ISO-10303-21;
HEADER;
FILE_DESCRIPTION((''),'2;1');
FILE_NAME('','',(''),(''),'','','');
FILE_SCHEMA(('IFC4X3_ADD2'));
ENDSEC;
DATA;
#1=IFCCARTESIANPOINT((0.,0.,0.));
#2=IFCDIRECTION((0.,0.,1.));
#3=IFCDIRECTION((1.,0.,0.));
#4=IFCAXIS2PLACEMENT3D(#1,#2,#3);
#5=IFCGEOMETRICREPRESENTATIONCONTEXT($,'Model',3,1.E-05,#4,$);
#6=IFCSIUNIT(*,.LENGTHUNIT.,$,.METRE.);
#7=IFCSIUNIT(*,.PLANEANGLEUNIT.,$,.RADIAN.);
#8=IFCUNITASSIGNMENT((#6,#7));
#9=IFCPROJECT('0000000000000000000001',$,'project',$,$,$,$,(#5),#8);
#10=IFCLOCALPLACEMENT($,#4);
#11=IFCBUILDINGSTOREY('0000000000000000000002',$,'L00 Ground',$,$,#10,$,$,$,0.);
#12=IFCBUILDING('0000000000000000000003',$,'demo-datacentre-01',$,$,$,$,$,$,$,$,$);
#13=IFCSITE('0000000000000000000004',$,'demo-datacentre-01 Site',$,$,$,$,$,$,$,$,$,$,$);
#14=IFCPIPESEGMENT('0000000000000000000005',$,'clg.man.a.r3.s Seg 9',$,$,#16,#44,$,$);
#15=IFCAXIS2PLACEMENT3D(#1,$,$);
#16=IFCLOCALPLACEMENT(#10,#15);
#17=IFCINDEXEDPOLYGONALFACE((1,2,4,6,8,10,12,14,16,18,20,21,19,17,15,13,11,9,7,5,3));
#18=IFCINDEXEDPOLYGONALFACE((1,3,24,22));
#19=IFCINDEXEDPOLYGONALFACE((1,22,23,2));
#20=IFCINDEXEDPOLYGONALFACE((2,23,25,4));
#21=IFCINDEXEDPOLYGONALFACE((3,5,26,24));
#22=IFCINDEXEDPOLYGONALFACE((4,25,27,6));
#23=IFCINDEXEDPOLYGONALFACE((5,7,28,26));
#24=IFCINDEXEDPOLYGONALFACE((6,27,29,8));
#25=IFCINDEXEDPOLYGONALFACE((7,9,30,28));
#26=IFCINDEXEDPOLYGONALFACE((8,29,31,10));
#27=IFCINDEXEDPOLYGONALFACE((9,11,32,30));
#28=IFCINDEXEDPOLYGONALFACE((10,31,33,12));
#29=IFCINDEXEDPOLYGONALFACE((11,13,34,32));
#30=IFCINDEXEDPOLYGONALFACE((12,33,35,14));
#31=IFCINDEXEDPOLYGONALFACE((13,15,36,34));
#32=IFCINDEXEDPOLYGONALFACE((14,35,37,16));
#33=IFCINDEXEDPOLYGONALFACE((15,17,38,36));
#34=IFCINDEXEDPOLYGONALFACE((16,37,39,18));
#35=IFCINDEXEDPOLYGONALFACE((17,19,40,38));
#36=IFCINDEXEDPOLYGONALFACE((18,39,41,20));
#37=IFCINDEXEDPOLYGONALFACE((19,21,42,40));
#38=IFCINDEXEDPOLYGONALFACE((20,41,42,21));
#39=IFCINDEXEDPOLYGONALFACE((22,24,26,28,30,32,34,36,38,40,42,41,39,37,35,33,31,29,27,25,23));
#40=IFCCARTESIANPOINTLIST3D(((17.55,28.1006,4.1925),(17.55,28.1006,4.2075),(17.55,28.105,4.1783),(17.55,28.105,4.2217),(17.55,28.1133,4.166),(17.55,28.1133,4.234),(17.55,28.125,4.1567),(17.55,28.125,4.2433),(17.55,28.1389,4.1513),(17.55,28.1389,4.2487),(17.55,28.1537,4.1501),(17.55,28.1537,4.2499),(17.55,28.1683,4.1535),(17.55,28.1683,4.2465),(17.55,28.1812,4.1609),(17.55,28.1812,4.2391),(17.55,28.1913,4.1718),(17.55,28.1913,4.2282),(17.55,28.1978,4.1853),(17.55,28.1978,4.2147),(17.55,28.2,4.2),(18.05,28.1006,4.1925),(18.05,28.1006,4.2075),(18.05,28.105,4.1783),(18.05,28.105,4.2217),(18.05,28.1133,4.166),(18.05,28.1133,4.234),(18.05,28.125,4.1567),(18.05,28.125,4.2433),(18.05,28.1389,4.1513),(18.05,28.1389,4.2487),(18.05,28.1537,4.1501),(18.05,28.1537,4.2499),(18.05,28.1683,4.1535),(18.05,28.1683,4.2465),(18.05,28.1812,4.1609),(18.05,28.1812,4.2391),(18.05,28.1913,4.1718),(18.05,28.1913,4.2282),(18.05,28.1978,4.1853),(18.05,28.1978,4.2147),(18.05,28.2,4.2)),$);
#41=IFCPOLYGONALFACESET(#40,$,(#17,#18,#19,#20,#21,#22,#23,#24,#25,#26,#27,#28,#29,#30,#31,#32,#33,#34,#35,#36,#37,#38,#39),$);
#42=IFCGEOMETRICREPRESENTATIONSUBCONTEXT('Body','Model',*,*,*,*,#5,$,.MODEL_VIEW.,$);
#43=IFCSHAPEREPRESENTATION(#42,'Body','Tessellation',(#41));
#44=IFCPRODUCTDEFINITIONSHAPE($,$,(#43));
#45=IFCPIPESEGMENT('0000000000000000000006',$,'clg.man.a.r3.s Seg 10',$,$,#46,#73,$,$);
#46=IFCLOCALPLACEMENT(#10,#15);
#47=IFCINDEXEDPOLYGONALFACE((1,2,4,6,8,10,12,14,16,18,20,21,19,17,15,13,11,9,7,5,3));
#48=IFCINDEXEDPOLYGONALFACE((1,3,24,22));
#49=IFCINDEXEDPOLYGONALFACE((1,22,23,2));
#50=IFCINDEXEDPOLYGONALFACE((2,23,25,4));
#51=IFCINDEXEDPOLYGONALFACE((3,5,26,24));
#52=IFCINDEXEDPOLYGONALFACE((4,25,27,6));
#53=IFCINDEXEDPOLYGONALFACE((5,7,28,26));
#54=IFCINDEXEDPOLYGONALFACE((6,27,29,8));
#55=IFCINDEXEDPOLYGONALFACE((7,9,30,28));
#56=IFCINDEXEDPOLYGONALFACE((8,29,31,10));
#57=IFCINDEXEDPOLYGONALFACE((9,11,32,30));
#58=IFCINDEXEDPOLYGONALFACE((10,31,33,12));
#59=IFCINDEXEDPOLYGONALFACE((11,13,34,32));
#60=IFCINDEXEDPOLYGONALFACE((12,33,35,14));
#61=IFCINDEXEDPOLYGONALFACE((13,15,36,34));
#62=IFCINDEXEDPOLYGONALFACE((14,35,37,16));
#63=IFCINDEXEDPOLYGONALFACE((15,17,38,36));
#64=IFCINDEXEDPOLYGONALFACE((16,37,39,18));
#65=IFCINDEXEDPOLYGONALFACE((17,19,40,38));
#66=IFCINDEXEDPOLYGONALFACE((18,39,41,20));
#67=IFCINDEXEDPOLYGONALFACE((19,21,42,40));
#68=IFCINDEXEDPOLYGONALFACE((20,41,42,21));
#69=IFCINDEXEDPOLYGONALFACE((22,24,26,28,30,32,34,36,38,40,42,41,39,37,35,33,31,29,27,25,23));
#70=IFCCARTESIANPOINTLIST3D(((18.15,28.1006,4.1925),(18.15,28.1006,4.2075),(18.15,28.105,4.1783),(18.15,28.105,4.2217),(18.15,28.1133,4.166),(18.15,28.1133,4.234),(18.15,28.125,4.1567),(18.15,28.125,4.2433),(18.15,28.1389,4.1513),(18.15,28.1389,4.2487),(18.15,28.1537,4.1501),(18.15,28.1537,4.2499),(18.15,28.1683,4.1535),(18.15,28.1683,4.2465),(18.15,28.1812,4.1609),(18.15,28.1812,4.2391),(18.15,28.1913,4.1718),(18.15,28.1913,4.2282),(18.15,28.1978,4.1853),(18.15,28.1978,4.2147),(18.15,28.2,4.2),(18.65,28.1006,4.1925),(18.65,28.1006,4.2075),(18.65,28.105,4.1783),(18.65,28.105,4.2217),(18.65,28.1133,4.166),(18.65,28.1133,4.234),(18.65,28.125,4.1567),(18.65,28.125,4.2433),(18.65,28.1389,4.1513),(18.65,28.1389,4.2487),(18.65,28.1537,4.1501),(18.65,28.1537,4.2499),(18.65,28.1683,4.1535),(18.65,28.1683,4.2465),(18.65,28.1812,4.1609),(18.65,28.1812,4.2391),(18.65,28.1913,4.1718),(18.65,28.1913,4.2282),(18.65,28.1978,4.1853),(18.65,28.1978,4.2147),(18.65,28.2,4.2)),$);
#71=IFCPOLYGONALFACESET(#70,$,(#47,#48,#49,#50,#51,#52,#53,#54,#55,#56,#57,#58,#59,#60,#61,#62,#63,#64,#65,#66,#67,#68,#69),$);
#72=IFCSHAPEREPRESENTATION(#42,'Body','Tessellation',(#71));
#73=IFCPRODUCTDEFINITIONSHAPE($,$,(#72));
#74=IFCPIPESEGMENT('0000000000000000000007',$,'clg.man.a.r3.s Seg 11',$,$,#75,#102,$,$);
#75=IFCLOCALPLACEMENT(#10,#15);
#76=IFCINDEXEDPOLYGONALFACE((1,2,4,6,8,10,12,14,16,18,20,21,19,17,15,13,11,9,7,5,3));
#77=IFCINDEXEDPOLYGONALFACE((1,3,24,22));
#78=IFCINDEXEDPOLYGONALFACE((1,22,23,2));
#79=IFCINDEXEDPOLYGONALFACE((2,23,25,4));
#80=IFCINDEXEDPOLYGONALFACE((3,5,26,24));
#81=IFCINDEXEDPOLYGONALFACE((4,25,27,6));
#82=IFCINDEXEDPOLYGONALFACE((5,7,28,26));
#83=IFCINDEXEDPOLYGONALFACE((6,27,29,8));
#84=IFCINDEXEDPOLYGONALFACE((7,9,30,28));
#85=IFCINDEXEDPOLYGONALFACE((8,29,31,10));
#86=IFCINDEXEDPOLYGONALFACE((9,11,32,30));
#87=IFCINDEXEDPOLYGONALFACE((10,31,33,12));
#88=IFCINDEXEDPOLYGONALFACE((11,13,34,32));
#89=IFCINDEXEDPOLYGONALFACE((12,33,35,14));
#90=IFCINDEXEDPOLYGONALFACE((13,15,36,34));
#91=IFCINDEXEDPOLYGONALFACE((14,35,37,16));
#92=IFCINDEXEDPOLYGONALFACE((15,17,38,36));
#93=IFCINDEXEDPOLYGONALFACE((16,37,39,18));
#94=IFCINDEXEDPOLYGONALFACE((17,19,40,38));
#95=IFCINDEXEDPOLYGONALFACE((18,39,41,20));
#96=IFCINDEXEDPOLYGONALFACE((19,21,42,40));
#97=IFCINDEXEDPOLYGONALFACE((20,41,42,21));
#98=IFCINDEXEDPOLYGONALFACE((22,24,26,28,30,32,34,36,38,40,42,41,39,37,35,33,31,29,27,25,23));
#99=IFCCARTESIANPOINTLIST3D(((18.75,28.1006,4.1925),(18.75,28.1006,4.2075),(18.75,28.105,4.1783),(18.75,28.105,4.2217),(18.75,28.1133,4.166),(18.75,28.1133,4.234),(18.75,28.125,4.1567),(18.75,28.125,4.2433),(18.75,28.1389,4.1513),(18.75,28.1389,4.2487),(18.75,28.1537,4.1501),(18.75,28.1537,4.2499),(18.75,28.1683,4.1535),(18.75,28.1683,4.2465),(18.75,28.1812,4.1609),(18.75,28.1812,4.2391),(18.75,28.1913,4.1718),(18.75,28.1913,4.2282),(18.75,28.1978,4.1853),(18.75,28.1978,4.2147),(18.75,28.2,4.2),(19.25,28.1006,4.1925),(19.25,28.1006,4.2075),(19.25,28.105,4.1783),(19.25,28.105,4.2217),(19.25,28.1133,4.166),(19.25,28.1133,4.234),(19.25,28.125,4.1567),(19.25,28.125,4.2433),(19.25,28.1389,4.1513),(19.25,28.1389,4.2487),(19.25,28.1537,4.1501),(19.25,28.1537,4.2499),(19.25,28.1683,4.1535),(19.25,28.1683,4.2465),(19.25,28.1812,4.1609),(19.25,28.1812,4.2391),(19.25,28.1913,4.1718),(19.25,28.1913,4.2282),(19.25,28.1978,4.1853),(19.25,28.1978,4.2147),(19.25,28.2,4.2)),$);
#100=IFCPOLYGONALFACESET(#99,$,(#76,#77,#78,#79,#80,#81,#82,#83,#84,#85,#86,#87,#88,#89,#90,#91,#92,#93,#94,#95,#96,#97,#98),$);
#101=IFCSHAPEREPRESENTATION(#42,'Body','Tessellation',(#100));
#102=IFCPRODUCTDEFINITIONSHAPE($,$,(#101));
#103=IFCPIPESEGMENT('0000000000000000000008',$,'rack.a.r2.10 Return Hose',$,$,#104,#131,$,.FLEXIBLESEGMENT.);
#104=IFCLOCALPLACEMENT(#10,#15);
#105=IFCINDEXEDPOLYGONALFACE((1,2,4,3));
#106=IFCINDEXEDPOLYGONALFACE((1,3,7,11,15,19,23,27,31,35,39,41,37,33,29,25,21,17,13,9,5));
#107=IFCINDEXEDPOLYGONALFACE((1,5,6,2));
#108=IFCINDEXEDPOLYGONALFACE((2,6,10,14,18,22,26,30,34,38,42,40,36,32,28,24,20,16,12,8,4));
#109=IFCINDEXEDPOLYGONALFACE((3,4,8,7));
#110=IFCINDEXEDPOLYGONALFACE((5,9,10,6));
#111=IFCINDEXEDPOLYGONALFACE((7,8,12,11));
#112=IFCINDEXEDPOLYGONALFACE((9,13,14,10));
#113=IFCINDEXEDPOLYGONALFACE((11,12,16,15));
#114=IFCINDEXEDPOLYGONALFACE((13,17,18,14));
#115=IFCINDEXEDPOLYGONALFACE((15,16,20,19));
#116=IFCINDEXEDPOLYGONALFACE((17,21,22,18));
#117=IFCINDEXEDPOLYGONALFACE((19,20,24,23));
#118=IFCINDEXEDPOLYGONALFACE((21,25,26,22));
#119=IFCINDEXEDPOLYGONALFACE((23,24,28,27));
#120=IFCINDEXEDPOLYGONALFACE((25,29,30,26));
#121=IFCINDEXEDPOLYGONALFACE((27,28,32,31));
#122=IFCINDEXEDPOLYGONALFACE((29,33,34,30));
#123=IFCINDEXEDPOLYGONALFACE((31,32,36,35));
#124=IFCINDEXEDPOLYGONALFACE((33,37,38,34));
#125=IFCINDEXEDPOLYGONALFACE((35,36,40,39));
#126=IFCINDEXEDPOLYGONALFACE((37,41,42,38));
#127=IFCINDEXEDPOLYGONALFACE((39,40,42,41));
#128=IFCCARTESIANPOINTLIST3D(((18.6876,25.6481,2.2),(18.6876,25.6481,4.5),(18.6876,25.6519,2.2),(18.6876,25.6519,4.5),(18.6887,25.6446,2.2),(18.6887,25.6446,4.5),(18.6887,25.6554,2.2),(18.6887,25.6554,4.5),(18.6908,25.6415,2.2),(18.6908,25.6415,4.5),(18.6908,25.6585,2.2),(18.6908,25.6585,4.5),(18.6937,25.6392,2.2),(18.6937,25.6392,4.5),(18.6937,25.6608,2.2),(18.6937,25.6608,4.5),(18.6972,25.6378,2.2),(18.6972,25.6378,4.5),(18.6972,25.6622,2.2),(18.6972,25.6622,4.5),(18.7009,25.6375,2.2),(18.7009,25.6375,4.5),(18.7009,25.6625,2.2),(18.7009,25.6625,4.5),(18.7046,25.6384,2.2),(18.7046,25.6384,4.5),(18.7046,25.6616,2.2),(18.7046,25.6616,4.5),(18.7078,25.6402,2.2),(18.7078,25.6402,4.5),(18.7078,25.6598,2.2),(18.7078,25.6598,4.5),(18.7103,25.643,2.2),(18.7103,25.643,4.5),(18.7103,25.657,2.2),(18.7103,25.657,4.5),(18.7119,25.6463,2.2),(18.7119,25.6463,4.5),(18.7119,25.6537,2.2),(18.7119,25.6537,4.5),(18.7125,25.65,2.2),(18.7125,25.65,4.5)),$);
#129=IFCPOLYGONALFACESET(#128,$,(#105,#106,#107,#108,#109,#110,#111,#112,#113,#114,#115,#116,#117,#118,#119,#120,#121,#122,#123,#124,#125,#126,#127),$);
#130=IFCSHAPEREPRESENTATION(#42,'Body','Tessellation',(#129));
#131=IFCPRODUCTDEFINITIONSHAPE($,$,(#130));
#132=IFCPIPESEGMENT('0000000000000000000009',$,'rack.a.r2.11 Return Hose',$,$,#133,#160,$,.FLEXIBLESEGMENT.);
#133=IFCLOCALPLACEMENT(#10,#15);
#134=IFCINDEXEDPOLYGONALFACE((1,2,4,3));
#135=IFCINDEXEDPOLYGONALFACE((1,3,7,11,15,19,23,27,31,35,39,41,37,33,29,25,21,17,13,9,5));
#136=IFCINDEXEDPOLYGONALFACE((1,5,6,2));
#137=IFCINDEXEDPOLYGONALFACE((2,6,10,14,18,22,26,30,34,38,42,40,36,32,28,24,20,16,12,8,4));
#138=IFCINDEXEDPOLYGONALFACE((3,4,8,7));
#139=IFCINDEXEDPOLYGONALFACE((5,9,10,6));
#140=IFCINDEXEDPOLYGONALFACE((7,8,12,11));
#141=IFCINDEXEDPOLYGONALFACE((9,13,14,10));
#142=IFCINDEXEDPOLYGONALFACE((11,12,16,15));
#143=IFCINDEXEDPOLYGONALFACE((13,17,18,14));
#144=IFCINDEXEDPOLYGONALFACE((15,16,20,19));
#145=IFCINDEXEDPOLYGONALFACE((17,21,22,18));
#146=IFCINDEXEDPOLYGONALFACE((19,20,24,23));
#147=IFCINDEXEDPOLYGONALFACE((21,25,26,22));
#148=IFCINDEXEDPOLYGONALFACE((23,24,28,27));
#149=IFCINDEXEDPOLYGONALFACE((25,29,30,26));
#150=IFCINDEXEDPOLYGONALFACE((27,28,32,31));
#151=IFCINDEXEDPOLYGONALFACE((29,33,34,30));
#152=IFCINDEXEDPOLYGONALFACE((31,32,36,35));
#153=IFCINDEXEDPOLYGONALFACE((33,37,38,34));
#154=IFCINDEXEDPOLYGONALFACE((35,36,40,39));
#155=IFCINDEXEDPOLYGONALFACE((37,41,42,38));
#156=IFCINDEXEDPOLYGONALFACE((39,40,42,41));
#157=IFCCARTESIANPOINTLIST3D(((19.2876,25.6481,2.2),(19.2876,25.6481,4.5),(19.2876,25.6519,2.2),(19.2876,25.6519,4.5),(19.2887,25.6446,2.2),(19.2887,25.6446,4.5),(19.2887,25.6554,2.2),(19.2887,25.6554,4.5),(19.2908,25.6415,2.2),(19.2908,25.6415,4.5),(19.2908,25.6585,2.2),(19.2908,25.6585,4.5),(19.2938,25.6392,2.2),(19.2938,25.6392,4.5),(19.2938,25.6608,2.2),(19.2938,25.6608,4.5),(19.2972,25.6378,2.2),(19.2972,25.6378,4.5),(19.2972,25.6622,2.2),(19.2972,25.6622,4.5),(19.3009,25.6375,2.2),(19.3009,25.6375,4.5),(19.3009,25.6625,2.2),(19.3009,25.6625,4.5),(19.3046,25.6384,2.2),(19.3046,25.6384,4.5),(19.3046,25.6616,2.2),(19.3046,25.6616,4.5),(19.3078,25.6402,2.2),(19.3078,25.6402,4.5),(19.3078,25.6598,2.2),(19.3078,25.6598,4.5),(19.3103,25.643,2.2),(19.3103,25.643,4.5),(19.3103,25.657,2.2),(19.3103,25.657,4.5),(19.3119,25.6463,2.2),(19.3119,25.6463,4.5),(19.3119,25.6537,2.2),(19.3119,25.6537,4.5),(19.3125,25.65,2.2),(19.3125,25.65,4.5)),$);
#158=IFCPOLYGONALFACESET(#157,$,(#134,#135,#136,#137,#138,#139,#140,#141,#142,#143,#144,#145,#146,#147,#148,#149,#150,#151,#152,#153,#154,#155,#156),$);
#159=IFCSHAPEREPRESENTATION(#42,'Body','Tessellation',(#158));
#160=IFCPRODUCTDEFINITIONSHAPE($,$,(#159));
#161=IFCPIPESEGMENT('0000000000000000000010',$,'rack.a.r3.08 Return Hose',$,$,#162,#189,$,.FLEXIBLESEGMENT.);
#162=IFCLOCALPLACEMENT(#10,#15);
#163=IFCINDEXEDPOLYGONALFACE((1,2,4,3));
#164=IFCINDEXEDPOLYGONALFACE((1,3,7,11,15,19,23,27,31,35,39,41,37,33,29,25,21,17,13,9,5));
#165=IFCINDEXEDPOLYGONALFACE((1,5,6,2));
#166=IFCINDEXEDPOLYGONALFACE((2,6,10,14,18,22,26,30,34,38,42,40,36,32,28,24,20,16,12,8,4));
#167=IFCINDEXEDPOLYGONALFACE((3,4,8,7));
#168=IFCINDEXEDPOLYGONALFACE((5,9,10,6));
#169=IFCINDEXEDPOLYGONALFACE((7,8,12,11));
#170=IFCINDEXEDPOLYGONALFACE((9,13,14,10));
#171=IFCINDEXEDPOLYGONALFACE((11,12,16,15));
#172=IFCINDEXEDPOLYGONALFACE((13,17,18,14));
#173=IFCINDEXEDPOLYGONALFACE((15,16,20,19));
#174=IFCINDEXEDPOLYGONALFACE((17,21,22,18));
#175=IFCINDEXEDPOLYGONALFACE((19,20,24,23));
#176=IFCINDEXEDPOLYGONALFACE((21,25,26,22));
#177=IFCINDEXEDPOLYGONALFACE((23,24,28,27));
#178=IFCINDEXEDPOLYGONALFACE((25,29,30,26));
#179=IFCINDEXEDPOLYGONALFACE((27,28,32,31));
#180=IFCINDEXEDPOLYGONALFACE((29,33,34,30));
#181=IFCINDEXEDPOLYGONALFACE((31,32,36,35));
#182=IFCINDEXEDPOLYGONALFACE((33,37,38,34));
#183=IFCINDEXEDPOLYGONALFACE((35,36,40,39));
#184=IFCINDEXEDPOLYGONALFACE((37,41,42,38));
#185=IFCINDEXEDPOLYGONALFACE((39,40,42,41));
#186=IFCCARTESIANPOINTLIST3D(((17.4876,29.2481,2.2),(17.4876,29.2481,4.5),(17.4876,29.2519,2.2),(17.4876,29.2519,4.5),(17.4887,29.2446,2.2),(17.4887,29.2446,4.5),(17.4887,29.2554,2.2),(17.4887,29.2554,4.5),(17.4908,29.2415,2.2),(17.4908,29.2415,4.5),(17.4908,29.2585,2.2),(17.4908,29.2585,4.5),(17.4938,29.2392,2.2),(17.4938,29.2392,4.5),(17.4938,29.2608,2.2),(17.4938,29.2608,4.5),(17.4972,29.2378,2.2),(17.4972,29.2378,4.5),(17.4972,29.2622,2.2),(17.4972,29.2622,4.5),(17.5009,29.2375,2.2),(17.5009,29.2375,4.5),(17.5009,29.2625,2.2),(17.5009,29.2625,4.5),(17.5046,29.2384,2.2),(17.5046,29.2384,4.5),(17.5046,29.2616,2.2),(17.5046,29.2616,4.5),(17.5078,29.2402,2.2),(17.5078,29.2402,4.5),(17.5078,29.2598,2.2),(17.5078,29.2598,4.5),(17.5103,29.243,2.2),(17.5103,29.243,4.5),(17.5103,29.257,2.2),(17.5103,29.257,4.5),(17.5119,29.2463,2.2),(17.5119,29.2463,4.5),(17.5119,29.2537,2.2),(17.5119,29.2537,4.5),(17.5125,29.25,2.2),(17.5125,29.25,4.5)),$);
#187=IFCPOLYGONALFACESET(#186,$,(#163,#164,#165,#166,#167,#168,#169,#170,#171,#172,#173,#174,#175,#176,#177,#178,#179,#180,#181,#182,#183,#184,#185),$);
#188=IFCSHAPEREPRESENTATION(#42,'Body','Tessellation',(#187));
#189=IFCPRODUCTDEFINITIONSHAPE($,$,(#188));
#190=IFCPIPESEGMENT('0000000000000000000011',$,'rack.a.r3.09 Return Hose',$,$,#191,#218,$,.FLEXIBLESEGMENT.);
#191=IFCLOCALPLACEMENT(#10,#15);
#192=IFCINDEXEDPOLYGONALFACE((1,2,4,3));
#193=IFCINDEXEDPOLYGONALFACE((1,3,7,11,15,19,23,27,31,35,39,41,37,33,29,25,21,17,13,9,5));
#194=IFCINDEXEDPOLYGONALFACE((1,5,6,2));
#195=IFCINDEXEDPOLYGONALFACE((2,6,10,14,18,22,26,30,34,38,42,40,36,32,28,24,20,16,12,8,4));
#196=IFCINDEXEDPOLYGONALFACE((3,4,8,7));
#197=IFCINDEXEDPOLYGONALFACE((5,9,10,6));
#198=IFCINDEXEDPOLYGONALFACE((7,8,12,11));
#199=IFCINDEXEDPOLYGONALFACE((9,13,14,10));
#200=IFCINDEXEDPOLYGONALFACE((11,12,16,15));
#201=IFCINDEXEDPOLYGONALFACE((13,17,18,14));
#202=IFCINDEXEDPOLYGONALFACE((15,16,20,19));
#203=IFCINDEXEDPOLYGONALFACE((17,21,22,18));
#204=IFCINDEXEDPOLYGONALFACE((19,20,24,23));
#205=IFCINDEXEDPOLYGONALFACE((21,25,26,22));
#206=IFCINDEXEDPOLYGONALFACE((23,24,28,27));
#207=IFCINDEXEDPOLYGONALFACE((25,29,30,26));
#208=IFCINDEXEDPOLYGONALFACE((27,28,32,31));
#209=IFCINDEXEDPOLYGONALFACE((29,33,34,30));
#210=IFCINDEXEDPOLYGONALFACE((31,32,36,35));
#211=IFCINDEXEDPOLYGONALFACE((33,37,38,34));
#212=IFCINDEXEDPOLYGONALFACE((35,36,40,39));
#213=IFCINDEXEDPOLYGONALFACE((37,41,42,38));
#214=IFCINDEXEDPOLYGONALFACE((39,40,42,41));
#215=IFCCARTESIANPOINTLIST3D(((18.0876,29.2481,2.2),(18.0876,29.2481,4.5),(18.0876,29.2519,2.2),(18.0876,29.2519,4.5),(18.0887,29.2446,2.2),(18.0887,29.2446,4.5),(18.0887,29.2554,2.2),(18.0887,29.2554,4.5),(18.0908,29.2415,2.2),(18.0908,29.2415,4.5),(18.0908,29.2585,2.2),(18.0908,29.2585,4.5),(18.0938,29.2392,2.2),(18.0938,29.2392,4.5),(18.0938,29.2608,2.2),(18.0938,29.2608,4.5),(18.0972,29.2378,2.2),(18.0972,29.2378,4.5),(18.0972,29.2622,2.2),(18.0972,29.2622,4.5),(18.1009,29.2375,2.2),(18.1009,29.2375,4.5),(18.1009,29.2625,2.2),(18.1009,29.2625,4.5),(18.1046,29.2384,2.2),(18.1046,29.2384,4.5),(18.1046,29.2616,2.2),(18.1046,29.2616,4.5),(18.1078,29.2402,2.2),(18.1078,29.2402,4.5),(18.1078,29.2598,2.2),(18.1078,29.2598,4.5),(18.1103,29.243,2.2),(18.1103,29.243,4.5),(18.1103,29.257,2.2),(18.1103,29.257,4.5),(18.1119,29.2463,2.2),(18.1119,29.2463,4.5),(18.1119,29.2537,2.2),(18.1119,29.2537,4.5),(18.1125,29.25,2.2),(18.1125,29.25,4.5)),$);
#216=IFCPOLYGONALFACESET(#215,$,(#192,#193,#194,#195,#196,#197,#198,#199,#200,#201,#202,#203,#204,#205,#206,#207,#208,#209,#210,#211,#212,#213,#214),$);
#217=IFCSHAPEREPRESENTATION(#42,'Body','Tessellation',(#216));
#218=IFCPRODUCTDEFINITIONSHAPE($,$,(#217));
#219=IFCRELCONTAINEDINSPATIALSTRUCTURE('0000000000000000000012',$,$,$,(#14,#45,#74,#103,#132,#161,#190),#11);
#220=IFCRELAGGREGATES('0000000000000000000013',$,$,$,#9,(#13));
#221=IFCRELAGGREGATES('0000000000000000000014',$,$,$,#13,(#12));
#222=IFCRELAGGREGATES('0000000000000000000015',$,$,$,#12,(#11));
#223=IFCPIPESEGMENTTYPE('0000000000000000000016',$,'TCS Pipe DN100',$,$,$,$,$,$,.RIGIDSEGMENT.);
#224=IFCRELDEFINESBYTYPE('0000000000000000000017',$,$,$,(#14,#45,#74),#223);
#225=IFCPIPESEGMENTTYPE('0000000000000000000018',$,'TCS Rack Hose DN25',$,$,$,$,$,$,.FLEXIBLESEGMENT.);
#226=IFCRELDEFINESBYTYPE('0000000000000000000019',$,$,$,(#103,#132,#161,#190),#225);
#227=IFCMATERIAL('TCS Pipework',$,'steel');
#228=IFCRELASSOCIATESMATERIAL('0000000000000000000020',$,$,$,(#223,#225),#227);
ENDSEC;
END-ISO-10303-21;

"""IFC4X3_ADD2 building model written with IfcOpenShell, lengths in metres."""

from ifc_helpers import new_model, si_unit, frame, origin_with_axes, place, context, subcontext, project, spatial, circle, extrude, material, type_object, element, save


model = new_model("IFC4X3_ADD2")

# Units and contexts
model_context = context("Model", 3, precision=1e-05, world=origin_with_axes())
body_context = subcontext(model_context, "Body", "Model", "MODEL_VIEW")
ifc_project = project(units=[si_unit("LENGTHUNIT", "METRE"), si_unit("PLANEANGLEUNIT", "RADIAN")], contexts=[model_context])

# Site, building, storey
site = spatial("IfcSite", under=ifc_project, Name="demo-datacentre-01 Site")
building = spatial("IfcBuilding", under=site, Name="demo-datacentre-01")
storey_placement = place(None, origin_with_axes())
storey = spatial("IfcBuildingStorey", under=building, at=storey_placement, Name="L00 Ground", Elevation=0.0)

# Shared definitions
ifc_material = material(Name="TCS Pipework", Category="steel")

# Pipe segments
pipe_segment_type_1 = type_object("IfcPipeSegmentType", Name="TCS Pipe DN100", PredefinedType="RIGIDSEGMENT", material=ifc_material)
for number, where, z_axis, x_axis, name in (
    (1, (17.55, 28.15, 4.2), (1.0, 0.0, 0.0), (0.0, 1.0, 0.0), "clg.man.a.r3.s Seg 9"),
):
    element("IfcPipeSegment", number, at=place(storey_placement, frame(where, z_axis=z_axis, x_axis=x_axis)), inside=storey, type_object=pipe_segment_type_1, Name=name, context=body_context, shape_type="SweptSolid", body=[
        extrude(circle(Radius=0.05), origin_with_axes(), (0.0, 0.0, 1.0), 0.5),
    ])
pipe_segment_1_placement = place(storey_placement, frame((18.15, 28.15, 4.2), z_axis=(1.0, 0.0, 0.0), x_axis=(0.0, 1.0, 0.0)))
element("IfcPipeSegment", 2, at=pipe_segment_1_placement, inside=storey, type_object=pipe_segment_type_1, Name="clg.man.a.r3.s Seg 10", context=body_context, shape_type="SweptSolid", body=[
    extrude(circle(Radius=0.05), origin_with_axes(), (0.0, 0.0, 1.0), 0.5),
])
pipe_segment_2_placement = place(storey_placement, frame((18.75, 28.15, 4.2), z_axis=(1.0, 0.0, 0.0), x_axis=(0.0, 1.0, 0.0)))
element("IfcPipeSegment", 3, at=pipe_segment_2_placement, inside=storey, type_object=pipe_segment_type_1, Name="clg.man.a.r3.s Seg 11", context=body_context, shape_type="SweptSolid", body=[
    extrude(circle(Radius=0.05), origin_with_axes(), (0.0, 0.0, 1.0), 0.5),
])
pipe_segment_type_2 = type_object("IfcPipeSegmentType", Name="TCS Rack Hose DN25", PredefinedType="FLEXIBLESEGMENT", material=ifc_material)
for number, where, z_axis, x_axis, name in (
    (4, (18.7, 25.65, 4.5), (0.0, 0.0, -1.0), (1.0, 0.0, 0.0), "rack.a.r2.10 Return Hose"),
    (5, (19.3, 25.65, 4.5), (0.0, 0.0, -1.0), (1.0, 0.0, 0.0), "rack.a.r2.11 Return Hose"),
    (6, (17.5, 29.25, 4.5), (0.0, 0.0, -1.0), (1.0, 0.0, 0.0), "rack.a.r3.08 Return Hose"),
    (7, (18.1, 29.25, 4.5), (0.0, 0.0, -1.0), (1.0, 0.0, 0.0), "rack.a.r3.09 Return Hose"),
):
    element("IfcPipeSegment", number, at=place(storey_placement, frame(where, z_axis=z_axis, x_axis=x_axis)), inside=storey, type_object=pipe_segment_type_2, Name=name, PredefinedType="FLEXIBLESEGMENT", context=body_context, shape_type="SweptSolid", body=[
        extrude(circle(Radius=0.0125), origin_with_axes(), (0.0, 0.0, 1.0), 2.3),
    ])

save(model, "model.ifc")
